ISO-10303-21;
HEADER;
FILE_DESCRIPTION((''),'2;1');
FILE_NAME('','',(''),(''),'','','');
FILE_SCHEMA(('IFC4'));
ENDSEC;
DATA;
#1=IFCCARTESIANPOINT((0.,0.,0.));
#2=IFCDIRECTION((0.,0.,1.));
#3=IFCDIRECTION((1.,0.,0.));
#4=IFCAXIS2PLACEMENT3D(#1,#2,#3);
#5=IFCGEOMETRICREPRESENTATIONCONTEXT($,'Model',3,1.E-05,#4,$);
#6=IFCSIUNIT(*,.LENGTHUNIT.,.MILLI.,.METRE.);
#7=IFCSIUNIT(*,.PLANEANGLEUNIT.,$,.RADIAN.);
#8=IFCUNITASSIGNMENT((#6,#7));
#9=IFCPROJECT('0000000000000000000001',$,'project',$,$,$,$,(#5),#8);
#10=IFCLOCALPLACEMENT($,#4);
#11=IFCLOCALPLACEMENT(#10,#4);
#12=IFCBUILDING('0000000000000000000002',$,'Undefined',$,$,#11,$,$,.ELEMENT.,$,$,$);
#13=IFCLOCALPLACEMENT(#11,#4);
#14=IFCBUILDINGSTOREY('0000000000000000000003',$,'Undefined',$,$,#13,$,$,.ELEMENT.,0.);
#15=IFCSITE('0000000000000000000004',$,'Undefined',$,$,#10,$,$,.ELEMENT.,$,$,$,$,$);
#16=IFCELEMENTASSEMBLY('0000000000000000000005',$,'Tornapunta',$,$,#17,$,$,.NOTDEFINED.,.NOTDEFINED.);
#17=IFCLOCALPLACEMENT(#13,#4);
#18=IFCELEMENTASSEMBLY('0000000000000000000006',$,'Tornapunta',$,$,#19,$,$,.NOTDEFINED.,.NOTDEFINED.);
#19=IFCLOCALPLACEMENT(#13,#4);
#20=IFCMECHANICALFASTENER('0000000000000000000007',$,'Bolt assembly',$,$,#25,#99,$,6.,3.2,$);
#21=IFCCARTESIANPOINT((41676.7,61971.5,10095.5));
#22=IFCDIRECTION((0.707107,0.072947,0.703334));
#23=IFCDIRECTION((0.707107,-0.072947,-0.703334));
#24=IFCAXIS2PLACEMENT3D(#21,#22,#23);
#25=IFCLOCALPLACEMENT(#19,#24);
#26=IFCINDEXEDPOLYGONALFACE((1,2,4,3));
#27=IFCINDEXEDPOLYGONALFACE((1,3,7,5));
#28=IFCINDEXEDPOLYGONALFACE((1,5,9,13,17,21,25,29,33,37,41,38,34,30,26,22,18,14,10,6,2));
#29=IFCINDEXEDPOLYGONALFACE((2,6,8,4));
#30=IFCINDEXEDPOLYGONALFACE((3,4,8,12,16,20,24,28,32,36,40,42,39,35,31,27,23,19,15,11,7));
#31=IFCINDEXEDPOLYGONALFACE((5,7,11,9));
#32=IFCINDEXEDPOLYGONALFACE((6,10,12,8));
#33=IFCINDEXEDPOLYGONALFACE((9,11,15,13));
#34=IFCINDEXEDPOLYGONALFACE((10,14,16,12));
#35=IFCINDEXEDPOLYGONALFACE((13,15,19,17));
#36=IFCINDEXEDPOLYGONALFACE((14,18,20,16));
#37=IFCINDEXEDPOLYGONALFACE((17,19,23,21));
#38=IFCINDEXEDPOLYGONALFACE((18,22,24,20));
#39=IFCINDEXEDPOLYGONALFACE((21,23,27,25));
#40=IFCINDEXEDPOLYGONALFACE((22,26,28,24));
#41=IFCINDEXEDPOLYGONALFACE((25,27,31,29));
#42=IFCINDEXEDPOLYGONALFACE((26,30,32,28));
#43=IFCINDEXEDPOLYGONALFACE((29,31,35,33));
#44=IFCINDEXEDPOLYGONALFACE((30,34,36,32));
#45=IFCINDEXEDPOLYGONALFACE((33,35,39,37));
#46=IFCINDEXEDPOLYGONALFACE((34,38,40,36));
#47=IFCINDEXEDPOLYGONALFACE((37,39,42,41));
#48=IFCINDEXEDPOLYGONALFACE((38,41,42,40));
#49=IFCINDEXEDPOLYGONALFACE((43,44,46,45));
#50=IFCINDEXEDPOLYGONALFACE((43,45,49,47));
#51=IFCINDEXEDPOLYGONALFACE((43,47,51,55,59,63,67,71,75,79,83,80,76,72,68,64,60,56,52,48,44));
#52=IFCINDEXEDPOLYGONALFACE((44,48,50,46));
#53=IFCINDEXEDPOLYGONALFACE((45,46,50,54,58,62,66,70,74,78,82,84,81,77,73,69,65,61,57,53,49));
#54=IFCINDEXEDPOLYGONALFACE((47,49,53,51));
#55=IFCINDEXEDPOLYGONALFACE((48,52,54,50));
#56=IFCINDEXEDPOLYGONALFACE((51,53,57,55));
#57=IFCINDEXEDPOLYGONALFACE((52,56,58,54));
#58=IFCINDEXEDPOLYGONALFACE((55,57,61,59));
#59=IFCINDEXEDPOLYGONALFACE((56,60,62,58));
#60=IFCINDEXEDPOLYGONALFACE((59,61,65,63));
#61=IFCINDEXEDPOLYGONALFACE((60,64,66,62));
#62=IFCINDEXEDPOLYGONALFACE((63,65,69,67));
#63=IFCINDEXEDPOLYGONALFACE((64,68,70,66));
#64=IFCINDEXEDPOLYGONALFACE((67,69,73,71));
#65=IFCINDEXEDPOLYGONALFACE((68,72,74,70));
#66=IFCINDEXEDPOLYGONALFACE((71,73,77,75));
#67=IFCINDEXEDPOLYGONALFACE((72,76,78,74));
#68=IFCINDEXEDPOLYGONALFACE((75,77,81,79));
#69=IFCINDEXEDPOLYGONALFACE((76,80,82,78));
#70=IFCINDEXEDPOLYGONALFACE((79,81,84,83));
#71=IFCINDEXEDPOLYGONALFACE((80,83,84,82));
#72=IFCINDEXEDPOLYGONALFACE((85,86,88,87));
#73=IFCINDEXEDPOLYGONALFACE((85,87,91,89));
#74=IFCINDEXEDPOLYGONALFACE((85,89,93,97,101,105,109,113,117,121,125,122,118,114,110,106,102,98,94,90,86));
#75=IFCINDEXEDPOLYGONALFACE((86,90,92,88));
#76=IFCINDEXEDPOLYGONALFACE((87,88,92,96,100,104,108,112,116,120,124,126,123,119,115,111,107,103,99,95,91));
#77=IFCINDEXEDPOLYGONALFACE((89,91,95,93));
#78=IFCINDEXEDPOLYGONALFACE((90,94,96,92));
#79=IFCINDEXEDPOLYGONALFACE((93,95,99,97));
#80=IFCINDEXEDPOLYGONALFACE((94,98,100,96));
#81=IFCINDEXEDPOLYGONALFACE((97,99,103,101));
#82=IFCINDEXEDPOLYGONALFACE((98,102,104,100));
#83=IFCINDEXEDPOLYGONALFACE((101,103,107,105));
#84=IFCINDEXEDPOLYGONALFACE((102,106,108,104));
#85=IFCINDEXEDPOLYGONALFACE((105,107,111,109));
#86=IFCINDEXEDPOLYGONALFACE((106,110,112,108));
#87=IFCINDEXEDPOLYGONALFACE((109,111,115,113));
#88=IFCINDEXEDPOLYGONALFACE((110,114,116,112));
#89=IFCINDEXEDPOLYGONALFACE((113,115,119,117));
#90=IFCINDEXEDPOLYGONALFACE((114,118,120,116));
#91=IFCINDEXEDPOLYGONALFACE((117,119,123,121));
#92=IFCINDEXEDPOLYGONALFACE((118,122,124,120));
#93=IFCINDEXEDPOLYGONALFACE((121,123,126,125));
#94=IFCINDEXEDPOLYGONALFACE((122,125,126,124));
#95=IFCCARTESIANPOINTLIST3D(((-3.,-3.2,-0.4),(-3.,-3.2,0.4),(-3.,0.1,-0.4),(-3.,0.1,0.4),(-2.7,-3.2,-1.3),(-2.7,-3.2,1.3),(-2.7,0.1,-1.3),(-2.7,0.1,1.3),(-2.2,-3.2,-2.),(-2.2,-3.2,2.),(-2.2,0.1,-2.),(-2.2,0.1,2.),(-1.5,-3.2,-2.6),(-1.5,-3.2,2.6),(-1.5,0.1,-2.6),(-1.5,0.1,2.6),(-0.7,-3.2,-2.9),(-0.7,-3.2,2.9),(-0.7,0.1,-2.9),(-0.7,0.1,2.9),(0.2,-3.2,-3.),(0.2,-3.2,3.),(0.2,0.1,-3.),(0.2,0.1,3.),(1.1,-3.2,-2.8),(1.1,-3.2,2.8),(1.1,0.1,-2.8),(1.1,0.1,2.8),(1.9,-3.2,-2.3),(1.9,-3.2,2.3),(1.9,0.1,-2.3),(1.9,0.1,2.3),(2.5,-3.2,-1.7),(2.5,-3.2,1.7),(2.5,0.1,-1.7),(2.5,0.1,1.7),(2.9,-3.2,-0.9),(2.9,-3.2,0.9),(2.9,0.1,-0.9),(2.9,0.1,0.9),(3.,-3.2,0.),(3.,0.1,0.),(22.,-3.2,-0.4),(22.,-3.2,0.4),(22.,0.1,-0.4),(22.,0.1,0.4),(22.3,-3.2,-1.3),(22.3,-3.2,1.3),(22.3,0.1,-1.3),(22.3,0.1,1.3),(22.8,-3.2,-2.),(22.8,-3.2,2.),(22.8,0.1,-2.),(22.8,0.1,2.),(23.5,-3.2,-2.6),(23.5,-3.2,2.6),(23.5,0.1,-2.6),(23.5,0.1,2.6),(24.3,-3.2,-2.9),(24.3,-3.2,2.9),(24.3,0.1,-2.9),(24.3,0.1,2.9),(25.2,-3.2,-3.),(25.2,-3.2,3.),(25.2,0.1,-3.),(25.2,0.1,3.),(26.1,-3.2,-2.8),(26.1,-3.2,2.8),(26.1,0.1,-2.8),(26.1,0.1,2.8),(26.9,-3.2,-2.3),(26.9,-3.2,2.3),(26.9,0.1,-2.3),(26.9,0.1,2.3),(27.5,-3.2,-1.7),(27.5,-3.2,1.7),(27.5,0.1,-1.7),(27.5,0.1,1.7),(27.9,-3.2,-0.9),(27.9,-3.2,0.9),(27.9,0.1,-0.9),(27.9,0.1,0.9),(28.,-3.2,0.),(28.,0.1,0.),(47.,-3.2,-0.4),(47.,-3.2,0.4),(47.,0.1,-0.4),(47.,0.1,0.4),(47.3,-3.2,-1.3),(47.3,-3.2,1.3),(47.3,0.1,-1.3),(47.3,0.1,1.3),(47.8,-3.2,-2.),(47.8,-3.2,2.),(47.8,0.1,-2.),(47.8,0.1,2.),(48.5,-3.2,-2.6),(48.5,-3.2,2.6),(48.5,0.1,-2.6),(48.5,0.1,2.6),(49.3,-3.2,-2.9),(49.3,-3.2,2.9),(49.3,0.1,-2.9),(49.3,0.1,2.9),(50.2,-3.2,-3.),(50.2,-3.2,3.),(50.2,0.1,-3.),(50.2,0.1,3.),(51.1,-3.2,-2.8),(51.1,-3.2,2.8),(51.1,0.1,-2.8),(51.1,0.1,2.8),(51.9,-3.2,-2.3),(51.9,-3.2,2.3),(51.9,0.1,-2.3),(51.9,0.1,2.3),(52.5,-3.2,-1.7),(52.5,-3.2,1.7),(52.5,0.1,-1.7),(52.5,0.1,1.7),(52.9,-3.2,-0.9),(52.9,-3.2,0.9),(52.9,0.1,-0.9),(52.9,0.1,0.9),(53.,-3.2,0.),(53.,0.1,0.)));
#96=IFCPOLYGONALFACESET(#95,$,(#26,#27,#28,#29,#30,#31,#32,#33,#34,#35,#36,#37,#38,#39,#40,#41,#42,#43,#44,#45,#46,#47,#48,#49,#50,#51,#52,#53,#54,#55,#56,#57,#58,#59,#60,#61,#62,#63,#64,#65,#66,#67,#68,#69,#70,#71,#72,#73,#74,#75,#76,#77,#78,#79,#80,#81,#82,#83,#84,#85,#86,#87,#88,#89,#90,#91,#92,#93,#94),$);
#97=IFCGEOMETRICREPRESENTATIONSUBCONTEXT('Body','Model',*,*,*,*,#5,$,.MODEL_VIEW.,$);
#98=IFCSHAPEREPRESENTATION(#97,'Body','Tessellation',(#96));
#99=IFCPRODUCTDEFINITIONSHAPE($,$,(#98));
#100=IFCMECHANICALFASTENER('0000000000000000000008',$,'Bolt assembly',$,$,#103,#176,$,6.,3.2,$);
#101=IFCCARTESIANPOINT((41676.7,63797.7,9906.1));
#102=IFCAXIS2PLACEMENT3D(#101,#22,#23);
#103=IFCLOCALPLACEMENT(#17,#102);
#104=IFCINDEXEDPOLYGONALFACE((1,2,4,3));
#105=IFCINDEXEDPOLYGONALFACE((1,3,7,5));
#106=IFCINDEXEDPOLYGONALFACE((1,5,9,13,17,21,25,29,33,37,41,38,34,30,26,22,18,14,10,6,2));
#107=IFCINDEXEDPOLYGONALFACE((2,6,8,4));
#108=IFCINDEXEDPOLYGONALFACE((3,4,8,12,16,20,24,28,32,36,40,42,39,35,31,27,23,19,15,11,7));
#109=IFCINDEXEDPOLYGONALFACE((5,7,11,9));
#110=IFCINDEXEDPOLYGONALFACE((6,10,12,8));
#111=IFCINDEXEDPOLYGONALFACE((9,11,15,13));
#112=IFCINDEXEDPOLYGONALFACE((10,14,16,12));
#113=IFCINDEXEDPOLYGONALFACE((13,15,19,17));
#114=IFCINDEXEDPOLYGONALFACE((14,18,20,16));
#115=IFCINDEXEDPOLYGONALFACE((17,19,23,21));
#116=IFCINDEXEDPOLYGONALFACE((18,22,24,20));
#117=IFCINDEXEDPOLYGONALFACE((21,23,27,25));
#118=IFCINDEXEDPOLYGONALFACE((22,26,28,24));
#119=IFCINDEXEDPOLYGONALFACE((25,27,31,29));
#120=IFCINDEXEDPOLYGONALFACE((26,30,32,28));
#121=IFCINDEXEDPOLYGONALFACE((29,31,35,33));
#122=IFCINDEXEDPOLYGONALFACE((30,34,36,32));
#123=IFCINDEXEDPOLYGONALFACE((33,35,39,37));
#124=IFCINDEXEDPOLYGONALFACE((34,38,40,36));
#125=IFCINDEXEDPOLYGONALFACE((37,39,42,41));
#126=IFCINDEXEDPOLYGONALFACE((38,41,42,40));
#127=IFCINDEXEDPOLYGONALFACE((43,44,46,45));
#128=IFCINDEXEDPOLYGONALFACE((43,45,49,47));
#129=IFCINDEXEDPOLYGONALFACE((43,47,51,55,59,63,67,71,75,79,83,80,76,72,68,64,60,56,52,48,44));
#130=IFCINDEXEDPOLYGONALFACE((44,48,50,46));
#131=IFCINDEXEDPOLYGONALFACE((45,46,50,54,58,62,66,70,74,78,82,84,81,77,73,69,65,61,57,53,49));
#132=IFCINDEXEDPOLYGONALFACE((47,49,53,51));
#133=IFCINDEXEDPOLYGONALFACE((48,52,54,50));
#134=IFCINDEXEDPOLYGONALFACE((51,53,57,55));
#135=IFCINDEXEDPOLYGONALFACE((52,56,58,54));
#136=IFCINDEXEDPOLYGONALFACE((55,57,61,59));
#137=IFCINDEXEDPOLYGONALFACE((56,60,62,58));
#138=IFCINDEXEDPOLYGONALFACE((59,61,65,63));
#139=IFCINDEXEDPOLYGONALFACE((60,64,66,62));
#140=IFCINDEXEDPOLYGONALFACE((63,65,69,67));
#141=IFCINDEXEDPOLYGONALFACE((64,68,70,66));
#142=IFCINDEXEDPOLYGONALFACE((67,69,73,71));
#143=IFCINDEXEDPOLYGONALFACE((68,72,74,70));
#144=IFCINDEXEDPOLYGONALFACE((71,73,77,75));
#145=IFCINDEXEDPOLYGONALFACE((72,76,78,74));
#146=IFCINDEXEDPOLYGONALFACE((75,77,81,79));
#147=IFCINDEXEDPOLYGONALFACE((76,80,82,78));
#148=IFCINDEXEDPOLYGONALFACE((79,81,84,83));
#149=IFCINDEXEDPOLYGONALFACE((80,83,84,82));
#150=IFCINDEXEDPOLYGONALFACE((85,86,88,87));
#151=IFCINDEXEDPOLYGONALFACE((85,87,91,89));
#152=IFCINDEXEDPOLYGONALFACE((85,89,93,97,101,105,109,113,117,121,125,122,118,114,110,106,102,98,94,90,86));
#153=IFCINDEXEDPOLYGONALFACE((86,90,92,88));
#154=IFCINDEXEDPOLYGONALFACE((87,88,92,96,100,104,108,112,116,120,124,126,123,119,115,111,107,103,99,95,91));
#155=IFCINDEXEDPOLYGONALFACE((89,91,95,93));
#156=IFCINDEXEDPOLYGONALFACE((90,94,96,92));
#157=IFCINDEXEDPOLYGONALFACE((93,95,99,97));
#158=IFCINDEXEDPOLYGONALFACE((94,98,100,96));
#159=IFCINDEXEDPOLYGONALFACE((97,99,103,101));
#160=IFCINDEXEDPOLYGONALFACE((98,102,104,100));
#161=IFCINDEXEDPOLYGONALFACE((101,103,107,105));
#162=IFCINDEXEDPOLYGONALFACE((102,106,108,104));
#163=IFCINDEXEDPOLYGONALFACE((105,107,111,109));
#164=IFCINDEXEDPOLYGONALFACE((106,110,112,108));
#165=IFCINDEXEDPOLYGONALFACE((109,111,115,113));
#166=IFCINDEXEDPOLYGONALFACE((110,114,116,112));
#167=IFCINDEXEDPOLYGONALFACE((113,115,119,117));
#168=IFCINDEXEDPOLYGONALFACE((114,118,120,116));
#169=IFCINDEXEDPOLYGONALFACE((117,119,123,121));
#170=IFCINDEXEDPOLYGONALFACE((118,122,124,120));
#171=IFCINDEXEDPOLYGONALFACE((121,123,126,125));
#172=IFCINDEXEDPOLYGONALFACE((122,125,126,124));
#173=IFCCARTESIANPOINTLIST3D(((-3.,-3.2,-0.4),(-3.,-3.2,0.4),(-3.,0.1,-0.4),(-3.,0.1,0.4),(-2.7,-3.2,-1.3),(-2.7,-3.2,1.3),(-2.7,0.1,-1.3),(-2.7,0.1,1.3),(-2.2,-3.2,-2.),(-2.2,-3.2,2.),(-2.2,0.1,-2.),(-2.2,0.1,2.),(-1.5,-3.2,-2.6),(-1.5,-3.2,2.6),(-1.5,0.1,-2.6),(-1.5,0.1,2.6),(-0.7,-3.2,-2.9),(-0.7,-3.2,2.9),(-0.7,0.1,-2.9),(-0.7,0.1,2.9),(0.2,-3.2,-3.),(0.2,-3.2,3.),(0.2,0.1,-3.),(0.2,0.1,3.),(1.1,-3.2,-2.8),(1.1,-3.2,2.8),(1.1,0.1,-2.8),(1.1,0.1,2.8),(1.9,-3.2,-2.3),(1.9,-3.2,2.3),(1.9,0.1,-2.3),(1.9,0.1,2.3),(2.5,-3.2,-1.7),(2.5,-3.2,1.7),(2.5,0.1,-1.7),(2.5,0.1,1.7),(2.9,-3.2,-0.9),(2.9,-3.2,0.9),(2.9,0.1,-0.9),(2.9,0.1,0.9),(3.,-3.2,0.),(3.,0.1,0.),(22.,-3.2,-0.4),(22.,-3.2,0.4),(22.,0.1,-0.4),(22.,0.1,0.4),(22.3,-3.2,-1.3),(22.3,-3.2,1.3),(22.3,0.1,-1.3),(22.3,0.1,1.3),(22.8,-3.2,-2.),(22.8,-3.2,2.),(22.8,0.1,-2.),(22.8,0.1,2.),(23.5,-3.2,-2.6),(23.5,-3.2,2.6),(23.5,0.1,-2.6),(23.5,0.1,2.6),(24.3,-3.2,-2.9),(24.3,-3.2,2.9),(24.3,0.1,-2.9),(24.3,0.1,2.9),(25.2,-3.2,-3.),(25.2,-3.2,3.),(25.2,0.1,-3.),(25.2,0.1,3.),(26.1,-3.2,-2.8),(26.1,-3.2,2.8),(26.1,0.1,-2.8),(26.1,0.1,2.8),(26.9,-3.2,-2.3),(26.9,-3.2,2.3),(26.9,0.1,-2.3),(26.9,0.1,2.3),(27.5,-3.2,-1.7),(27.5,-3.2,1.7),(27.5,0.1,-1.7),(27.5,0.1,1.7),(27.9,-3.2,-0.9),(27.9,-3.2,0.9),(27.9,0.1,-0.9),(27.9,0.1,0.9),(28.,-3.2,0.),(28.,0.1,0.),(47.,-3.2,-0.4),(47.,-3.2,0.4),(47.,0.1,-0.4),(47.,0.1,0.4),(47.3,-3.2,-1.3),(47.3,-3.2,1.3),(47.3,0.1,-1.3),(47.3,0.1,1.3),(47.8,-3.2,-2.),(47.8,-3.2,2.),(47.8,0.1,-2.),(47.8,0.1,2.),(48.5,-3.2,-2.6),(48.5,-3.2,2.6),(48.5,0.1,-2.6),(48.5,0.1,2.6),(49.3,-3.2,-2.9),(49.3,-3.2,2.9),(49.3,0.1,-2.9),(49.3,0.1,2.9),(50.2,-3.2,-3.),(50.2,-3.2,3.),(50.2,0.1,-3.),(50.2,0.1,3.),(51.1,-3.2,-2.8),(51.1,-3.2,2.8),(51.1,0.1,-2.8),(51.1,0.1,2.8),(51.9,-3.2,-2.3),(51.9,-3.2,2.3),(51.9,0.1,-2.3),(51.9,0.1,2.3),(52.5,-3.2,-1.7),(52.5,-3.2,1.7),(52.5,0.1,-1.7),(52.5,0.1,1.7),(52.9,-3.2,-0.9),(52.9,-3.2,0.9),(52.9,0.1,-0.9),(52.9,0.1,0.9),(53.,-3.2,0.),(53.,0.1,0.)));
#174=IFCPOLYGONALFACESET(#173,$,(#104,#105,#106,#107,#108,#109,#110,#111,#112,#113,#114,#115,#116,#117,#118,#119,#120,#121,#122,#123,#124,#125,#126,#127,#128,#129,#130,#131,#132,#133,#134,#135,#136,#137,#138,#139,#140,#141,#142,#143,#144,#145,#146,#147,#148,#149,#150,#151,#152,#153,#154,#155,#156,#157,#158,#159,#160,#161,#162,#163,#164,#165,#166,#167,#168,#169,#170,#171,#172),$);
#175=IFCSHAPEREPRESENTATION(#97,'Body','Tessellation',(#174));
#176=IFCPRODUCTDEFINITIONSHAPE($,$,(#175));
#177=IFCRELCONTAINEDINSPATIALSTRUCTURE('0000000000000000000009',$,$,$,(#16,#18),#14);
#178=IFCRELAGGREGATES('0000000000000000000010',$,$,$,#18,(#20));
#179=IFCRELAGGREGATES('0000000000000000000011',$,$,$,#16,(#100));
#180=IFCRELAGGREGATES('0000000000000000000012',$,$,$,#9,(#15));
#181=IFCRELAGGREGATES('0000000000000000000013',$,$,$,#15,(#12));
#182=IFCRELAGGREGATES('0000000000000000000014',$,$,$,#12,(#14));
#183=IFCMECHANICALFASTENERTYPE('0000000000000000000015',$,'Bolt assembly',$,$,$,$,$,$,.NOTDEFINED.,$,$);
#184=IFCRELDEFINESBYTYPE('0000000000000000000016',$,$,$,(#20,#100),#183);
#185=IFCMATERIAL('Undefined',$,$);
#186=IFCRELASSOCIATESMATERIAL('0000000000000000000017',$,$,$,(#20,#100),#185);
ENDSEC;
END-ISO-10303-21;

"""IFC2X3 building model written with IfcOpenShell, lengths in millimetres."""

from ifc_helpers import new_model, si_unit, frame, origin_with_axes, origin_2d_with_axis, place, context, subcontext, project, spatial, circle, extrude, source, transform, mapped, material, type_object, element, aggregate, save


model = new_model("IFC2X3")

# Units and contexts
model_context = context("Model", 3, precision=1e-05, world=origin_with_axes())
body_context = subcontext(model_context, "Body", "Model", "MODEL_VIEW")
ifc_project = project(units=[si_unit("LENGTHUNIT", "METRE", prefix="MILLI"), si_unit("PLANEANGLEUNIT", "RADIAN")], contexts=[model_context])

# Site, building, storey
site_placement = place(None, origin_with_axes())
site = spatial("IfcSite", under=ifc_project, at=site_placement, Name="Undefined", CompositionType="ELEMENT")
building_placement = place(site_placement, origin_with_axes())
building = spatial("IfcBuilding", under=site, at=building_placement, Name="Undefined", CompositionType="ELEMENT")
storey_placement = place(building_placement, origin_with_axes())
storey = spatial("IfcBuildingStorey", under=building, at=storey_placement, Name="Undefined", CompositionType="ELEMENT", Elevation=0.0)

# Element assembly
assembly_1_placement = place(storey_placement, origin_with_axes())
assembly_1 = element("IfcElementAssembly", 1, at=assembly_1_placement, inside=storey, Name="Tornapunta", AssemblyPlace="NOTDEFINED", PredefinedType="NOTDEFINED")

# Element assembly, mechanical fastener
assembly_2_placement = place(storey_placement, origin_with_axes())
assembly_2 = element("IfcElementAssembly", 2, at=assembly_2_placement, inside=storey, Name="Tornapunta", AssemblyPlace="NOTDEFINED", PredefinedType="NOTDEFINED")
ifc_material_1 = material(Name="Undefined")
mechanical_fastener_type = type_object("IfcMechanicalFastenerType", Name="Bolt assembly")
shared_shape_1 = source(origin_with_axes(), body_context, "Body", "SweptSolid", [
    extrude(circle(Radius=3.0, at=origin_2d_with_axis()), frame((0.0, -3.2, 0.0), z_axis=(0.0, 1.0, 0.0), x_axis=(1.0, 0.0, 0.0)), (0.0, 0.0, 1.0), 3.3),
])
mechanical_fastener_1_placement = place(assembly_2_placement, frame((41676.7, 61971.5, 10095.5), z_axis=(0.707107, 0.072947, 0.703334), x_axis=(0.707107, -0.072947, -0.703334)))
mechanical_fastener_1 = element("IfcMechanicalFastener", 3, at=mechanical_fastener_1_placement, type_object=mechanical_fastener_type, material=ifc_material_1, Name="Bolt assembly", NominalDiameter=6.0, NominalLength=3.2, context=body_context, shape_type="MappedRepresentation", body=[
    mapped(shared_shape_1, transform((0.0, 0.0, 0.0))),
    mapped(shared_shape_1, transform((25.0, 0.0, 0.0))),
    mapped(shared_shape_1, transform((50.0, 0.0, 0.0))),
])
aggregate(assembly_2, [mechanical_fastener_1])

# Mechanical fastener
mechanical_fastener_2_placement = place(assembly_1_placement, frame((41676.7, 63797.7, 9906.1), z_axis=(0.707107, 0.072947, 0.703334), x_axis=(0.707107, -0.072947, -0.703334)))
mechanical_fastener_2 = element("IfcMechanicalFastener", 4, at=mechanical_fastener_2_placement, type_object=mechanical_fastener_type, material=ifc_material_1, Name="Bolt assembly", NominalDiameter=6.0, NominalLength=3.2, context=body_context, shape_type="MappedRepresentation", body=[
    mapped(shared_shape_1, transform((0.0, 0.0, 0.0))),
    mapped(shared_shape_1, transform((25.0, 0.0, 0.0))),
    mapped(shared_shape_1, transform((50.0, 0.0, 0.0))),
])

aggregate(assembly_1, [mechanical_fastener_2])

save(model, "model.ifc")
